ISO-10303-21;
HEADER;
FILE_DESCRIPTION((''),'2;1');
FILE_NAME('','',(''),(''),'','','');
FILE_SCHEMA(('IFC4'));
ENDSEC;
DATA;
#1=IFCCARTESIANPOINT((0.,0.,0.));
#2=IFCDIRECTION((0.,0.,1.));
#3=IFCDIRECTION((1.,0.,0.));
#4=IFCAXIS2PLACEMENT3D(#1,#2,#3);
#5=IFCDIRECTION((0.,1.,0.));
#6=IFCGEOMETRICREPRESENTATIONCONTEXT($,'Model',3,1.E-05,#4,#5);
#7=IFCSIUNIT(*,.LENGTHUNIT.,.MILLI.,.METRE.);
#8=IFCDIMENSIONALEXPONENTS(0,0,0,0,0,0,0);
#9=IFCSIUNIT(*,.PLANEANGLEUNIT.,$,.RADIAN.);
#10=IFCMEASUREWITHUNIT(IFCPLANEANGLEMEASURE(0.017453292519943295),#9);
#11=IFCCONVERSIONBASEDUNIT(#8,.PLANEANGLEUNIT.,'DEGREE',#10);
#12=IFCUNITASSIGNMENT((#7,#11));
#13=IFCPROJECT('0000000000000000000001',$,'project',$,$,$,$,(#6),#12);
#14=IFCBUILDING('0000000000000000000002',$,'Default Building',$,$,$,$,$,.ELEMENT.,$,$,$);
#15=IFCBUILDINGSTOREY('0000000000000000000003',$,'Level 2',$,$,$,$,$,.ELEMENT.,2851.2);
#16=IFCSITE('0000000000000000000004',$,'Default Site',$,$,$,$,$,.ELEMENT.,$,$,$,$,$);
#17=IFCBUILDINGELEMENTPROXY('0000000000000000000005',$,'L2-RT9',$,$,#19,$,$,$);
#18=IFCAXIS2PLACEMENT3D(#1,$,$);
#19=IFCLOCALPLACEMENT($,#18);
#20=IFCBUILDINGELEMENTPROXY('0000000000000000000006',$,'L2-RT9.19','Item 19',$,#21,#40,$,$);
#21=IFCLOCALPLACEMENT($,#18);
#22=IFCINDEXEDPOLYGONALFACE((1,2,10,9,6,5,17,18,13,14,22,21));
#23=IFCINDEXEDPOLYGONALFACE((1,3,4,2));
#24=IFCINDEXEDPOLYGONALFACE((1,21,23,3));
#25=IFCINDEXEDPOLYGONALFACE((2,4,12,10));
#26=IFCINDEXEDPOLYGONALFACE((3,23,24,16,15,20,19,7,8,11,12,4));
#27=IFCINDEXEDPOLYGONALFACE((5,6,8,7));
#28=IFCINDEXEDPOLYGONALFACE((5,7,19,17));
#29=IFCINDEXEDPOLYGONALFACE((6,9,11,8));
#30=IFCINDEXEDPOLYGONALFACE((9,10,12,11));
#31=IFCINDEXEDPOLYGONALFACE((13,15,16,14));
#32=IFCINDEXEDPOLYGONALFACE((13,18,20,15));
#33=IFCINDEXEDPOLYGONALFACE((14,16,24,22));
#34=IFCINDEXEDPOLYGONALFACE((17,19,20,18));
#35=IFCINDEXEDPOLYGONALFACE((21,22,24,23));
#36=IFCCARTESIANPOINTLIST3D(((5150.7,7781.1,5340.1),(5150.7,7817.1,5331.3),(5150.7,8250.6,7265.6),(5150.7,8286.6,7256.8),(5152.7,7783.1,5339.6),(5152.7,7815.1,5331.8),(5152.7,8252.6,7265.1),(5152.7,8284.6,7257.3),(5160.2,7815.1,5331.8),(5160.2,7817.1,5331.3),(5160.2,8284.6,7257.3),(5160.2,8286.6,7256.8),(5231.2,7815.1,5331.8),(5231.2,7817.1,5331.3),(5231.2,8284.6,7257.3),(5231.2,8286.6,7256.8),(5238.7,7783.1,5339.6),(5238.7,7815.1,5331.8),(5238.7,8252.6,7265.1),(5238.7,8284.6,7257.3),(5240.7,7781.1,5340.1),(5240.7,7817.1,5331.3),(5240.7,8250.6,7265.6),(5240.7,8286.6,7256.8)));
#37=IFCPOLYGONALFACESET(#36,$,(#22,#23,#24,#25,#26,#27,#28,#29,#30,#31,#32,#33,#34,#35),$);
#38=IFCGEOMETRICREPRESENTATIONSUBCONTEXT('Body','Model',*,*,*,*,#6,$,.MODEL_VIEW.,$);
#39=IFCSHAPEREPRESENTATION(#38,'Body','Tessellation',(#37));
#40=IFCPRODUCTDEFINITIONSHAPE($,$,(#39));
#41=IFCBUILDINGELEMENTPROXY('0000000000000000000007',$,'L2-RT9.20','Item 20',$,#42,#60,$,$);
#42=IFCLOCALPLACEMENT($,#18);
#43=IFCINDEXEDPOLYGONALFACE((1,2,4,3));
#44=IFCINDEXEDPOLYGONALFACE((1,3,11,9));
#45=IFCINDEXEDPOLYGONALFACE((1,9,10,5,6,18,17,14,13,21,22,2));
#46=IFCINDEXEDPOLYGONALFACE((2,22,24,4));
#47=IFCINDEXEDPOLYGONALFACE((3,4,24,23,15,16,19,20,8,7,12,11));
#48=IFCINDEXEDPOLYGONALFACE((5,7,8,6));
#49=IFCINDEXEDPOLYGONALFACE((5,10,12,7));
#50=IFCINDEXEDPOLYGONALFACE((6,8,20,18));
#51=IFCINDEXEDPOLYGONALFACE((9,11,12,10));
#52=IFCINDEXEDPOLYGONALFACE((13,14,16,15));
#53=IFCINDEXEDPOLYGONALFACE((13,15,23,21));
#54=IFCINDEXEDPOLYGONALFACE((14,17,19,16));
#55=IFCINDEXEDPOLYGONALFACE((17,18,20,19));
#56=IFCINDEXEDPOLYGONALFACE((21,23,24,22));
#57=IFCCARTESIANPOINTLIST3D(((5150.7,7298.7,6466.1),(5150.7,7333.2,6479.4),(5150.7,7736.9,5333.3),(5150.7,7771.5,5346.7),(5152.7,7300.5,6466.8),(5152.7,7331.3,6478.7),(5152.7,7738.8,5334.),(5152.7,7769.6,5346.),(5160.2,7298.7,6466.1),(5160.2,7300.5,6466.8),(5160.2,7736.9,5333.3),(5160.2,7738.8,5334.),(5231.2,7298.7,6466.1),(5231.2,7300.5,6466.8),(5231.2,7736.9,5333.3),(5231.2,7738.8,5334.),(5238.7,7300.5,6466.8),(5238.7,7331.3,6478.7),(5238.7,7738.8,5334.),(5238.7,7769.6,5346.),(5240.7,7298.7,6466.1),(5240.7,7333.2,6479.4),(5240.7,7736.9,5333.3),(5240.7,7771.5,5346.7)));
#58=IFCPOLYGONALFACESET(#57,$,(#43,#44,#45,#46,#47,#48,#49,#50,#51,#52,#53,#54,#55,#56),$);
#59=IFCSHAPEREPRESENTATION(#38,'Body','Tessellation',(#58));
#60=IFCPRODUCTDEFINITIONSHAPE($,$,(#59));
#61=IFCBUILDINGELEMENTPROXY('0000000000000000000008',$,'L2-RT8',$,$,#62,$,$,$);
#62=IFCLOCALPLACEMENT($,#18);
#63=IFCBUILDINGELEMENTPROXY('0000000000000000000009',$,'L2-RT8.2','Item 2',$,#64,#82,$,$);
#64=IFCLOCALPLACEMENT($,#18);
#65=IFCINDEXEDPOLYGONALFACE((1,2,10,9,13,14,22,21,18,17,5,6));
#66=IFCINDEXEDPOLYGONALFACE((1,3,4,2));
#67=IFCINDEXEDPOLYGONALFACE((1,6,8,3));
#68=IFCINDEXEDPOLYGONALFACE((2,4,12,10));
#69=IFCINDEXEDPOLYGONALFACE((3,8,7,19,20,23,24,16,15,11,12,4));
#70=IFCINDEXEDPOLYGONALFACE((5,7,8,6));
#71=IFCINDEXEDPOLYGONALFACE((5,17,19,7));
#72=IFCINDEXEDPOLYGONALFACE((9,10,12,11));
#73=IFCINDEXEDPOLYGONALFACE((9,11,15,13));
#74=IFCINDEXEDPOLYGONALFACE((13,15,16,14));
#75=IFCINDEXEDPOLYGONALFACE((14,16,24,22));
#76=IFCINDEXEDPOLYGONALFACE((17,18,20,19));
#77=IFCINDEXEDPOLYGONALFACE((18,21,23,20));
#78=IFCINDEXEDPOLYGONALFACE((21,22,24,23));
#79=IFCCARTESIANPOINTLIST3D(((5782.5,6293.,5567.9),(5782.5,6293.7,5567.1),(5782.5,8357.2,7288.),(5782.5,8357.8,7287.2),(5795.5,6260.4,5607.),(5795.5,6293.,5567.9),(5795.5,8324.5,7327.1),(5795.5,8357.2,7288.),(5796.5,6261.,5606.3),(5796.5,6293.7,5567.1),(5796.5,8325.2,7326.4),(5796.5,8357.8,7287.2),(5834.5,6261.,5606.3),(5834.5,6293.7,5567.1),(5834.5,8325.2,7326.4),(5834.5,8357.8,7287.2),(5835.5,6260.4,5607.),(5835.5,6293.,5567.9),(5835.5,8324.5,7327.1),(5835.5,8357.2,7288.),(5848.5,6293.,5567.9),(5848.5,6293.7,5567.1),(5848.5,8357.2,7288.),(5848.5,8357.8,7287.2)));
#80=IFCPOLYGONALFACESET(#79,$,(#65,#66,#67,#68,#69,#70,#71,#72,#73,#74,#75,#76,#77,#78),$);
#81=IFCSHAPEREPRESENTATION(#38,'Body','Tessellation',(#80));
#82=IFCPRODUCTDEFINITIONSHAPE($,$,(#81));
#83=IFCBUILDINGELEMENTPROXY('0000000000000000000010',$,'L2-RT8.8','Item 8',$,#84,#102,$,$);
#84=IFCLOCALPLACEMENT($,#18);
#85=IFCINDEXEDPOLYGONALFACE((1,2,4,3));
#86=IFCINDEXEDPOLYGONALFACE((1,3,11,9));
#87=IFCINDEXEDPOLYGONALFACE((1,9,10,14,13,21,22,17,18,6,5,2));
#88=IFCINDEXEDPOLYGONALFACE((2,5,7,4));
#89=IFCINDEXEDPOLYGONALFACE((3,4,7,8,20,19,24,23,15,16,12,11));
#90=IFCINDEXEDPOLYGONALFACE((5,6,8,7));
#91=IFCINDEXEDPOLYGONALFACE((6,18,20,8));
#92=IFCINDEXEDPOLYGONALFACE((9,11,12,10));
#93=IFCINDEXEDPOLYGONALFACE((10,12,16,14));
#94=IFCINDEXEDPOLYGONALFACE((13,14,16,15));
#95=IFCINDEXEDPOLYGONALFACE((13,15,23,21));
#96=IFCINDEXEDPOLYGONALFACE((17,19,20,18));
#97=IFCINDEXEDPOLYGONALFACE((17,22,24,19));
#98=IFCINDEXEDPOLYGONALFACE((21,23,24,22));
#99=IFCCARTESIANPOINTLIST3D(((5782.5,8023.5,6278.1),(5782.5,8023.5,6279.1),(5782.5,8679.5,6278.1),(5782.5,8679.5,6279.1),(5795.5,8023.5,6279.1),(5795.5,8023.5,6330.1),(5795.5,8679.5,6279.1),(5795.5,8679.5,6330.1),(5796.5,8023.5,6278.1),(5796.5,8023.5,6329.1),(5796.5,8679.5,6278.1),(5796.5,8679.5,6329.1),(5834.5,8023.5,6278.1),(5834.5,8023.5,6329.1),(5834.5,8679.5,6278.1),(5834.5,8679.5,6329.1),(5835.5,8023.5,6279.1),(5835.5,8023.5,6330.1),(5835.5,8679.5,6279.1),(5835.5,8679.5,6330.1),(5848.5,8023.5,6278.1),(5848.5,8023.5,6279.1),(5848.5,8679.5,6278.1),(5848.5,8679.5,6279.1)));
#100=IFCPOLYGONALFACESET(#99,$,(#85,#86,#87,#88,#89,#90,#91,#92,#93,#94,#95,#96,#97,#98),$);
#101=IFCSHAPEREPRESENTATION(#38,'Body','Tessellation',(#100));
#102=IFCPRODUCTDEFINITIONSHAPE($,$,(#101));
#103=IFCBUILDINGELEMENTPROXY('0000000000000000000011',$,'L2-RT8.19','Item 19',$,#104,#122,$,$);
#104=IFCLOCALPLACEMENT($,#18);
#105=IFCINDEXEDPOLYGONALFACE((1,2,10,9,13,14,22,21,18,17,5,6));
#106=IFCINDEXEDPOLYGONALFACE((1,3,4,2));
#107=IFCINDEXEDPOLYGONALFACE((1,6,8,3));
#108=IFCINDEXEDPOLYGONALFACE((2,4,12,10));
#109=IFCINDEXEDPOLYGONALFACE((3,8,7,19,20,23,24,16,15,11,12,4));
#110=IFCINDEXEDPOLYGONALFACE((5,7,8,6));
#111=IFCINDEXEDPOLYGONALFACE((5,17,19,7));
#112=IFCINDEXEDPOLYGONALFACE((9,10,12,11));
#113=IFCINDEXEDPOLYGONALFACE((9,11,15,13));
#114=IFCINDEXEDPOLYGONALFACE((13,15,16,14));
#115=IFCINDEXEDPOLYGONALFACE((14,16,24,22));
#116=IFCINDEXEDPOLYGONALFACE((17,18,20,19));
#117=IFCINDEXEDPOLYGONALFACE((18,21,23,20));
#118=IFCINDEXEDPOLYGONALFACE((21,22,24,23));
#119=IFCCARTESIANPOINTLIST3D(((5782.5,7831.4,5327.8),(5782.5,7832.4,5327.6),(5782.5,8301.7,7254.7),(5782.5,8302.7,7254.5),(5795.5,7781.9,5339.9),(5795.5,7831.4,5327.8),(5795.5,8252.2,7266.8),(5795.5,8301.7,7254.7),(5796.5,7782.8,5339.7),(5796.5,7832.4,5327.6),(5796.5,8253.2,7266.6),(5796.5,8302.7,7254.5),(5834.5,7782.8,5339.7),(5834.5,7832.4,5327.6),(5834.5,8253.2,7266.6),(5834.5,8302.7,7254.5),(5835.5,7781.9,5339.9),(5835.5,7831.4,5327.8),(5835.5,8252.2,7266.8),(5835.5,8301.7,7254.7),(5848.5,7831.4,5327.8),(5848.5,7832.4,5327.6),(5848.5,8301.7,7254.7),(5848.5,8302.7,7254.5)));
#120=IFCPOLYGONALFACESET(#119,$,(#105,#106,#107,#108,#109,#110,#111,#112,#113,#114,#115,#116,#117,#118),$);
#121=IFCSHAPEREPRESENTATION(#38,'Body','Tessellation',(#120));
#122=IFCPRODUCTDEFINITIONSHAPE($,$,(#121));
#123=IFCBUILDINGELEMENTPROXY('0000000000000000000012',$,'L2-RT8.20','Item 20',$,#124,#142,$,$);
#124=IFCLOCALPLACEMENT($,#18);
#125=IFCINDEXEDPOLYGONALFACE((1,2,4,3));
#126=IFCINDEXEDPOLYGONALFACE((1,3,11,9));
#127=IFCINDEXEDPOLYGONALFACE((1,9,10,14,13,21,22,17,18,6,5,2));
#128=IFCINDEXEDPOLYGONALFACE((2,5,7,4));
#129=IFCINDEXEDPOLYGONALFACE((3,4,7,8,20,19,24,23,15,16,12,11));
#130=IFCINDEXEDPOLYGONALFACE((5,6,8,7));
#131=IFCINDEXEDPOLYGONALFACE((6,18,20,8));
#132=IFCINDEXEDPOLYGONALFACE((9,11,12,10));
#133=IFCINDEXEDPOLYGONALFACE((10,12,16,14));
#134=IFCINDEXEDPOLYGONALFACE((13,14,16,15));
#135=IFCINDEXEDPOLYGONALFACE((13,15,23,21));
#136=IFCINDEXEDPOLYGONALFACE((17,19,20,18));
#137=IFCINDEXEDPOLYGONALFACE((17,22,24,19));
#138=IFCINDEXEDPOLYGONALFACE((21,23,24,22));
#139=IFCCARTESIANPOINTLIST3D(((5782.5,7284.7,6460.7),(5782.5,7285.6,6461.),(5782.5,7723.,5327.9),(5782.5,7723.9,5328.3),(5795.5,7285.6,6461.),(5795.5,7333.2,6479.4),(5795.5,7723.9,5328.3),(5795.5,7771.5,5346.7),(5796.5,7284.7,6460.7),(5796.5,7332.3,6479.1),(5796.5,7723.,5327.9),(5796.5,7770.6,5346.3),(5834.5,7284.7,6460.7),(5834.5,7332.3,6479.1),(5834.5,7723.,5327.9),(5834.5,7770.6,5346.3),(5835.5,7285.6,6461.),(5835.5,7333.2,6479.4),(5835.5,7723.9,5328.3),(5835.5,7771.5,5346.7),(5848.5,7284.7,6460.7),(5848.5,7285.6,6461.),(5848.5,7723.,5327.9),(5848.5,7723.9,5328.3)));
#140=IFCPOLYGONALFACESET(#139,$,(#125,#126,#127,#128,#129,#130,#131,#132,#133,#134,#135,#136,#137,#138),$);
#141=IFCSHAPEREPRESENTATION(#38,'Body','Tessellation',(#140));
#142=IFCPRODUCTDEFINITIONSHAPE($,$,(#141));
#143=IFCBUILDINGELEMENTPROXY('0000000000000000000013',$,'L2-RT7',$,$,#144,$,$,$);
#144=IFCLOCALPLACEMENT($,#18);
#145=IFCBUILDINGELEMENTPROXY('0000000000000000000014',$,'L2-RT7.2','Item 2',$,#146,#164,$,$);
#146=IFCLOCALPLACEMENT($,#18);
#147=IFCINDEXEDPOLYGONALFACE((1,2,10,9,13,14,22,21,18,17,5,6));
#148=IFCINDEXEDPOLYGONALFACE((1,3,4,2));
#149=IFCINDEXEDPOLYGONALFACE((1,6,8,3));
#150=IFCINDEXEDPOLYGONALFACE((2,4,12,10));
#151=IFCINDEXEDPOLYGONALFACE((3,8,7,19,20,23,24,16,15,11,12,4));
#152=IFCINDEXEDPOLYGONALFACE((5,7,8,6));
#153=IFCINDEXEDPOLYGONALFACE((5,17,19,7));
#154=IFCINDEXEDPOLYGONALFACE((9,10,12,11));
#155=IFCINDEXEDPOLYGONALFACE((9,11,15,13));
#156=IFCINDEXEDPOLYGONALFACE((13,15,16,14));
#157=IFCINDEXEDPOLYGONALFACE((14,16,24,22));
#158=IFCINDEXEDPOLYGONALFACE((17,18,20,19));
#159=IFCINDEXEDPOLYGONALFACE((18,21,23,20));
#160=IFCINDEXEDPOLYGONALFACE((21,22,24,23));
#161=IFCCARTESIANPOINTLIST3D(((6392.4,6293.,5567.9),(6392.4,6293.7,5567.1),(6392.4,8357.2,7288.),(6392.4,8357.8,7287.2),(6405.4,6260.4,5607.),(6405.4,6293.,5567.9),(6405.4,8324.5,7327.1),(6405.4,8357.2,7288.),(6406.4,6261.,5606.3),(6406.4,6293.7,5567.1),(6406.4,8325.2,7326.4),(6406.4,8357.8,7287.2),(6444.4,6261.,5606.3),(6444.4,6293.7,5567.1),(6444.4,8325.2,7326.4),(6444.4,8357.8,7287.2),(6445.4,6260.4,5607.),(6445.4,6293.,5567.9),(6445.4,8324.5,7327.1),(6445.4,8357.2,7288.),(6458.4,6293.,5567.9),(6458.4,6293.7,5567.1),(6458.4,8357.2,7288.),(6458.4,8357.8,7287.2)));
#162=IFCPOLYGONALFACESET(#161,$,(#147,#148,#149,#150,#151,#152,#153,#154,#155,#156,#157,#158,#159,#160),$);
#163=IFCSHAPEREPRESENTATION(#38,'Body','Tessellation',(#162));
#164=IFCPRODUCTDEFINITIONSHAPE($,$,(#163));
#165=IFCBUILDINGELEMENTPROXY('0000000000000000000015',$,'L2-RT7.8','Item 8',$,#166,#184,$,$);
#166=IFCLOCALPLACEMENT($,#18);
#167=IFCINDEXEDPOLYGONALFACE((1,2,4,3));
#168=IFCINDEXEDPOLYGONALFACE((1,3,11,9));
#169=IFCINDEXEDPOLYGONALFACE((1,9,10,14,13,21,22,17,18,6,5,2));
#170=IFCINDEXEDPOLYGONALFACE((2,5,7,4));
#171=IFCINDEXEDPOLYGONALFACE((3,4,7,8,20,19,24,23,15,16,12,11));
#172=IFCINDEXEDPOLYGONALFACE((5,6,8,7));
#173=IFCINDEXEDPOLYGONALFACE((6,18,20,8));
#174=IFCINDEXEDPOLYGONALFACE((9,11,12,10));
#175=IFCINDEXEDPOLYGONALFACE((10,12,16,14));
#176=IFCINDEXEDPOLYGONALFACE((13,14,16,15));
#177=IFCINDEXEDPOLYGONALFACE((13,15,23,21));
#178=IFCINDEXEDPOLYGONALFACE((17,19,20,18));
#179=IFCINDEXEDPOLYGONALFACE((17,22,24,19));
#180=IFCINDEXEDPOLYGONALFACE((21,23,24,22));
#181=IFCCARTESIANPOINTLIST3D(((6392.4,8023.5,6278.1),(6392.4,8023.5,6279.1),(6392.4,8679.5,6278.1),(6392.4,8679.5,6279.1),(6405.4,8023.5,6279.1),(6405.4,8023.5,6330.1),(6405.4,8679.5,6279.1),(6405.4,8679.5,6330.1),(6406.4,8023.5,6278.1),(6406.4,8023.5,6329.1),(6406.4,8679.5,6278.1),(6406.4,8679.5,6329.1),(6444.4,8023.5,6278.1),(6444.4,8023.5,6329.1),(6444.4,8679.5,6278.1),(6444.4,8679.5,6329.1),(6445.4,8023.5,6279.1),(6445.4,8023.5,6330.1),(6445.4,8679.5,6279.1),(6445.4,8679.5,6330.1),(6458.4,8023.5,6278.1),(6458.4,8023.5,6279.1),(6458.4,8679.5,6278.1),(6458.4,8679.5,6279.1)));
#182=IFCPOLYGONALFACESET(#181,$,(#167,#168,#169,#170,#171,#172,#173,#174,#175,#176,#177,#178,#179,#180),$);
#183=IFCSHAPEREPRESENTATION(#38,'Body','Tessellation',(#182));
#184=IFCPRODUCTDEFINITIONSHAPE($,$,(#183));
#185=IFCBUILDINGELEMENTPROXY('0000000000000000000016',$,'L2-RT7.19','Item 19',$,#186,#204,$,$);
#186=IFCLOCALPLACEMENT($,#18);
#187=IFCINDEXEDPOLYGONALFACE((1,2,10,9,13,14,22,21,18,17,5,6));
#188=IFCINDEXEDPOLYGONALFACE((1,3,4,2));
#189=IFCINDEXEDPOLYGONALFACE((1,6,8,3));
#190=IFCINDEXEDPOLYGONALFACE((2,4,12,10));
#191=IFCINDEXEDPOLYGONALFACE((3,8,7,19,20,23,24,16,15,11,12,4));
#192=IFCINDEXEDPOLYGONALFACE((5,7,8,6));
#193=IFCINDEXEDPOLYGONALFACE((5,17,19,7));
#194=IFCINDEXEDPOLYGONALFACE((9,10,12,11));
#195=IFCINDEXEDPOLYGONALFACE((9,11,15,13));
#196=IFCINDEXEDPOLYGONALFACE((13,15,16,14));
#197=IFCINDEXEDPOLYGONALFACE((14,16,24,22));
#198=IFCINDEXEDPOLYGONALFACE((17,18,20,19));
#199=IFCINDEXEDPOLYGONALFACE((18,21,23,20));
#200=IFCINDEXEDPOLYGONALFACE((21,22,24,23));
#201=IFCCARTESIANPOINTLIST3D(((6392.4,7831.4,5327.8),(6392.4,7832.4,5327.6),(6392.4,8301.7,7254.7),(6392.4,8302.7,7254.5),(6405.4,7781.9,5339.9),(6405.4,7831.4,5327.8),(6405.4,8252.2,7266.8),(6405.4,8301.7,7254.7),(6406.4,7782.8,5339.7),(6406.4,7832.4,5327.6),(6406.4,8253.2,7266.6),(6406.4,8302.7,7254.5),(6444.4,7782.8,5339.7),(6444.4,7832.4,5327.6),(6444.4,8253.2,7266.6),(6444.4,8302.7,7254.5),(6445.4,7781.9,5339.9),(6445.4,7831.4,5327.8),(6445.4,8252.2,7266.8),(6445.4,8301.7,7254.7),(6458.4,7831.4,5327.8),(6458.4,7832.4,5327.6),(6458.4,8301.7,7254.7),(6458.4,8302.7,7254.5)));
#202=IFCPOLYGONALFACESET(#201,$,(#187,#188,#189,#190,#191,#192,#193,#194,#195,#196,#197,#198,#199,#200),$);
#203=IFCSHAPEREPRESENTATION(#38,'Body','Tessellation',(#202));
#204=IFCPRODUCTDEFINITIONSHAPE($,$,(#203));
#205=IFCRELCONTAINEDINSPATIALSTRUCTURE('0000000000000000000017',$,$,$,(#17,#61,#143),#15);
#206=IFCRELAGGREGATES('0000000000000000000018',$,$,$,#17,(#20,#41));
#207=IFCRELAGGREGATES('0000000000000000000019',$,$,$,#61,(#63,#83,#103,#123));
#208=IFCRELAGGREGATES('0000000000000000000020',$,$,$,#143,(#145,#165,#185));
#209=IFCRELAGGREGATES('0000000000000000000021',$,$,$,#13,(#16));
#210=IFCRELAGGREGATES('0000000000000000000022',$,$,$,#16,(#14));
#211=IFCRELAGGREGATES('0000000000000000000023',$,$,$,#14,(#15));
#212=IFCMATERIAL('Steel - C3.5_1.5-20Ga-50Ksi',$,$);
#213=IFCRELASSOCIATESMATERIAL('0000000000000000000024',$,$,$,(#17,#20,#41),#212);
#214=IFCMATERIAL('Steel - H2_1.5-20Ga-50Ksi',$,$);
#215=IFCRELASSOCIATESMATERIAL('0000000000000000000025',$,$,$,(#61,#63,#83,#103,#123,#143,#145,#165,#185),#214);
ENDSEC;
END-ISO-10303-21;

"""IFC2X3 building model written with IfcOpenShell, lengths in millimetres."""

from ifc_helpers import new_model, entity, si_unit, converted_unit, direction, frame, origin, origin_with_axes, origin_2d_with_axis, place, context, subcontext, project, spatial, polyline, c_section, outline, extrude, material, element, aggregate, save


model = new_model("IFC2X3")

# Units and contexts
model_context = context("Model", 3, precision=1e-05, world=origin_with_axes(), true_north=direction((0.0, 1.0, 0.0)))
body_context = subcontext(model_context, "Body", "Model", "MODEL_VIEW")
ifc_project = project(units=[si_unit("LENGTHUNIT", "METRE", prefix="MILLI"), converted_unit("PLANEANGLEUNIT", "DEGREE", entity("IfcPlaneAngleMeasure", 0.017453292519943295), si_unit("PLANEANGLEUNIT", "RADIAN"), dimensions=[0, 0, 0, 0, 0, 0, 0])], contexts=[model_context])

# Site, building, storey
site = spatial("IfcSite", under=ifc_project, Name="Default Site", CompositionType="ELEMENT")
building = spatial("IfcBuilding", under=site, Name="Default Building", CompositionType="ELEMENT")
storey = spatial("IfcBuildingStorey", under=building, Name="Level 2", CompositionType="ELEMENT", Elevation=2851.2)

# Shared definitions
ifc_material_1 = material(Name="Steel - C3.5_1.5-20Ga-50Ksi")

# Building element proxies
proxy_1 = element("IfcBuildingElementProxy", 1, inside=storey, material=ifc_material_1, Name="L2-RT9")
proxy_2_placement = place(None, frame((5195.7, 8268.6, 7261.2), z_axis=(0.0, -0.237, -0.972), x_axis=(0.0, 35.95, -8.754)))
proxy_2 = element("IfcBuildingElementProxy", 2, at=proxy_2_placement, material=ifc_material_1, Name="L2-RT9.19", Description="Item 19", context=body_context, shape_type="SweptSolid", body=[
    extrude(c_section(Depth=90.0, Width=37.0, WallThickness=2.0, Girth=9.5, at=origin_2d_with_axis()), origin(), (0.0, 0.0, 1.0), 1981.9),
])
proxy_3_placement = place(None, frame((5195.7, 7754.2, 5340.0), z_axis=(0.0, -0.361, 0.933), x_axis=(0.0, -34.503, -13.361)))
proxy_3 = element("IfcBuildingElementProxy", 3, at=proxy_3_placement, material=ifc_material_1, Name="L2-RT9.20", Description="Item 20", context=body_context, shape_type="SweptSolid", body=[
    extrude(c_section(Depth=90.0, Width=37.0, WallThickness=2.0, Girth=9.5, at=origin_2d_with_axis()), origin(), (0.0, 0.0, 1.0), 1214.6),
])
aggregate(proxy_1, [proxy_2, proxy_3])
ifc_material_2 = material(Name="Steel - H2_1.5-20Ga-50Ksi")
proxy_4 = element("IfcBuildingElementProxy", 4, inside=storey, material=ifc_material_2, Name="L2-RT8")
proxy_5_placement = place(None, frame((5782.5, 8357.8, 7287.2), z_axis=(0.0, -0.768, -0.64), x_axis=(40.0, 0.0, 0.0)))
proxy_5 = element("IfcBuildingElementProxy", 5, at=proxy_5_placement, material=ifc_material_2, Name="L2-RT8.2", Description="Item 2", context=body_context, shape_type="SweptSolid", body=[
    extrude(outline(polyline([(0.0, 0.0), (14.0, 0.0), (14.0, 51.0), (52.0, 51.0), (52.0, 0.0), (66.0, 0.0), (66.0, 1.0), (53.0, 1.0), (53.0, 52.0), (13.0, 52.0), (13.0, 1.0), (0.0, 1.0), (0.0, 0.0)])), origin(), (0.0, 0.0, 1.0), 2686.9),
])
proxy_6_placement = place(None, frame((5782.5, 8679.5, 6278.1), z_axis=(0.0, -1.0, 0.0), x_axis=(40.0, 0.0, 0.0)))
proxy_6 = element("IfcBuildingElementProxy", 6, at=proxy_6_placement, material=ifc_material_2, Name="L2-RT8.8", Description="Item 8", context=body_context, shape_type="SweptSolid", body=[
    extrude(outline(polyline([(0.0, 0.0), (14.0, 0.0), (14.0, 51.0), (52.0, 51.0), (52.0, 0.0), (66.0, 0.0), (66.0, 1.0), (53.0, 1.0), (53.0, 52.0), (13.0, 52.0), (13.0, 1.0), (0.0, 1.0), (0.0, 0.0)])), origin(), (0.0, 0.0, 1.0), 656.0),
])
proxy_7_placement = place(None, frame((5782.5, 8302.7, 7254.5), z_axis=(0.0, -0.237, -0.971), x_axis=(40.0, 0.0, 0.0)))
proxy_7 = element("IfcBuildingElementProxy", 7, at=proxy_7_placement, material=ifc_material_2, Name="L2-RT8.19", Description="Item 19", context=body_context, shape_type="SweptSolid", body=[
    extrude(outline(polyline([(0.0, 0.0), (14.0, 0.0), (14.0, 51.0), (52.0, 51.0), (52.0, 0.0), (66.0, 0.0), (66.0, 1.0), (53.0, 1.0), (53.0, 52.0), (13.0, 52.0), (13.0, 1.0), (0.0, 1.0), (0.0, 0.0)])), origin(), (0.0, 0.0, 1.0), 1983.5),
])
proxy_8_placement = place(None, frame((5782.5, 7723.0, 5327.9), z_axis=(0.0, -0.361, 0.933), x_axis=(40.0, 0.0, 0.0)))
proxy_8 = element("IfcBuildingElementProxy", 8, at=proxy_8_placement, material=ifc_material_2, Name="L2-RT8.20", Description="Item 20", context=body_context, shape_type="SweptSolid", body=[
    extrude(outline(polyline([(0.0, 0.0), (14.0, 0.0), (14.0, 51.0), (52.0, 51.0), (52.0, 0.0), (66.0, 0.0), (66.0, 1.0), (53.0, 1.0), (53.0, 52.0), (13.0, 52.0), (13.0, 1.0), (0.0, 1.0), (0.0, 0.0)])), origin(), (0.0, 0.0, 1.0), 1214.6),
])
aggregate(proxy_4, [proxy_5, proxy_6, proxy_7, proxy_8])
proxy_9 = element("IfcBuildingElementProxy", 9, inside=storey, material=ifc_material_2, Name="L2-RT7")
proxy_10_placement = place(None, frame((6392.4, 8357.8, 7287.2), z_axis=(0.0, -0.768, -0.64), x_axis=(40.0, 0.0, 0.0)))
proxy_10 = element("IfcBuildingElementProxy", 10, at=proxy_10_placement, material=ifc_material_2, Name="L2-RT7.2", Description="Item 2", context=body_context, shape_type="SweptSolid", body=[
    extrude(outline(polyline([(0.0, 0.0), (14.0, 0.0), (14.0, 51.0), (52.0, 51.0), (52.0, 0.0), (66.0, 0.0), (66.0, 1.0), (53.0, 1.0), (53.0, 52.0), (13.0, 52.0), (13.0, 1.0), (0.0, 1.0), (0.0, 0.0)])), origin(), (0.0, 0.0, 1.0), 2686.9),
])
proxy_11_placement = place(None, frame((6392.4, 8679.5, 6278.1), z_axis=(0.0, -1.0, 0.0), x_axis=(40.0, 0.0, 0.0)))
proxy_11 = element("IfcBuildingElementProxy", 11, at=proxy_11_placement, material=ifc_material_2, Name="L2-RT7.8", Description="Item 8", context=body_context, shape_type="SweptSolid", body=[
    extrude(outline(polyline([(0.0, 0.0), (14.0, 0.0), (14.0, 51.0), (52.0, 51.0), (52.0, 0.0), (66.0, 0.0), (66.0, 1.0), (53.0, 1.0), (53.0, 52.0), (13.0, 52.0), (13.0, 1.0), (0.0, 1.0), (0.0, 0.0)])), origin(), (0.0, 0.0, 1.0), 656.0),
])
proxy_12_placement = place(None, frame((6392.4, 8302.7, 7254.5), z_axis=(0.0, -0.237, -0.971), x_axis=(40.0, 0.0, 0.0)))
proxy_12 = element("IfcBuildingElementProxy", 12, at=proxy_12_placement, material=ifc_material_2, Name="L2-RT7.19", Description="Item 19", context=body_context, shape_type="SweptSolid", body=[
    extrude(outline(polyline([(0.0, 0.0), (14.0, 0.0), (14.0, 51.0), (52.0, 51.0), (52.0, 0.0), (66.0, 0.0), (66.0, 1.0), (53.0, 1.0), (53.0, 52.0), (13.0, 52.0), (13.0, 1.0), (0.0, 1.0), (0.0, 0.0)])), origin(), (0.0, 0.0, 1.0), 1983.5),
])
aggregate(proxy_9, [proxy_10, proxy_11, proxy_12])

save(model, "model.ifc")
